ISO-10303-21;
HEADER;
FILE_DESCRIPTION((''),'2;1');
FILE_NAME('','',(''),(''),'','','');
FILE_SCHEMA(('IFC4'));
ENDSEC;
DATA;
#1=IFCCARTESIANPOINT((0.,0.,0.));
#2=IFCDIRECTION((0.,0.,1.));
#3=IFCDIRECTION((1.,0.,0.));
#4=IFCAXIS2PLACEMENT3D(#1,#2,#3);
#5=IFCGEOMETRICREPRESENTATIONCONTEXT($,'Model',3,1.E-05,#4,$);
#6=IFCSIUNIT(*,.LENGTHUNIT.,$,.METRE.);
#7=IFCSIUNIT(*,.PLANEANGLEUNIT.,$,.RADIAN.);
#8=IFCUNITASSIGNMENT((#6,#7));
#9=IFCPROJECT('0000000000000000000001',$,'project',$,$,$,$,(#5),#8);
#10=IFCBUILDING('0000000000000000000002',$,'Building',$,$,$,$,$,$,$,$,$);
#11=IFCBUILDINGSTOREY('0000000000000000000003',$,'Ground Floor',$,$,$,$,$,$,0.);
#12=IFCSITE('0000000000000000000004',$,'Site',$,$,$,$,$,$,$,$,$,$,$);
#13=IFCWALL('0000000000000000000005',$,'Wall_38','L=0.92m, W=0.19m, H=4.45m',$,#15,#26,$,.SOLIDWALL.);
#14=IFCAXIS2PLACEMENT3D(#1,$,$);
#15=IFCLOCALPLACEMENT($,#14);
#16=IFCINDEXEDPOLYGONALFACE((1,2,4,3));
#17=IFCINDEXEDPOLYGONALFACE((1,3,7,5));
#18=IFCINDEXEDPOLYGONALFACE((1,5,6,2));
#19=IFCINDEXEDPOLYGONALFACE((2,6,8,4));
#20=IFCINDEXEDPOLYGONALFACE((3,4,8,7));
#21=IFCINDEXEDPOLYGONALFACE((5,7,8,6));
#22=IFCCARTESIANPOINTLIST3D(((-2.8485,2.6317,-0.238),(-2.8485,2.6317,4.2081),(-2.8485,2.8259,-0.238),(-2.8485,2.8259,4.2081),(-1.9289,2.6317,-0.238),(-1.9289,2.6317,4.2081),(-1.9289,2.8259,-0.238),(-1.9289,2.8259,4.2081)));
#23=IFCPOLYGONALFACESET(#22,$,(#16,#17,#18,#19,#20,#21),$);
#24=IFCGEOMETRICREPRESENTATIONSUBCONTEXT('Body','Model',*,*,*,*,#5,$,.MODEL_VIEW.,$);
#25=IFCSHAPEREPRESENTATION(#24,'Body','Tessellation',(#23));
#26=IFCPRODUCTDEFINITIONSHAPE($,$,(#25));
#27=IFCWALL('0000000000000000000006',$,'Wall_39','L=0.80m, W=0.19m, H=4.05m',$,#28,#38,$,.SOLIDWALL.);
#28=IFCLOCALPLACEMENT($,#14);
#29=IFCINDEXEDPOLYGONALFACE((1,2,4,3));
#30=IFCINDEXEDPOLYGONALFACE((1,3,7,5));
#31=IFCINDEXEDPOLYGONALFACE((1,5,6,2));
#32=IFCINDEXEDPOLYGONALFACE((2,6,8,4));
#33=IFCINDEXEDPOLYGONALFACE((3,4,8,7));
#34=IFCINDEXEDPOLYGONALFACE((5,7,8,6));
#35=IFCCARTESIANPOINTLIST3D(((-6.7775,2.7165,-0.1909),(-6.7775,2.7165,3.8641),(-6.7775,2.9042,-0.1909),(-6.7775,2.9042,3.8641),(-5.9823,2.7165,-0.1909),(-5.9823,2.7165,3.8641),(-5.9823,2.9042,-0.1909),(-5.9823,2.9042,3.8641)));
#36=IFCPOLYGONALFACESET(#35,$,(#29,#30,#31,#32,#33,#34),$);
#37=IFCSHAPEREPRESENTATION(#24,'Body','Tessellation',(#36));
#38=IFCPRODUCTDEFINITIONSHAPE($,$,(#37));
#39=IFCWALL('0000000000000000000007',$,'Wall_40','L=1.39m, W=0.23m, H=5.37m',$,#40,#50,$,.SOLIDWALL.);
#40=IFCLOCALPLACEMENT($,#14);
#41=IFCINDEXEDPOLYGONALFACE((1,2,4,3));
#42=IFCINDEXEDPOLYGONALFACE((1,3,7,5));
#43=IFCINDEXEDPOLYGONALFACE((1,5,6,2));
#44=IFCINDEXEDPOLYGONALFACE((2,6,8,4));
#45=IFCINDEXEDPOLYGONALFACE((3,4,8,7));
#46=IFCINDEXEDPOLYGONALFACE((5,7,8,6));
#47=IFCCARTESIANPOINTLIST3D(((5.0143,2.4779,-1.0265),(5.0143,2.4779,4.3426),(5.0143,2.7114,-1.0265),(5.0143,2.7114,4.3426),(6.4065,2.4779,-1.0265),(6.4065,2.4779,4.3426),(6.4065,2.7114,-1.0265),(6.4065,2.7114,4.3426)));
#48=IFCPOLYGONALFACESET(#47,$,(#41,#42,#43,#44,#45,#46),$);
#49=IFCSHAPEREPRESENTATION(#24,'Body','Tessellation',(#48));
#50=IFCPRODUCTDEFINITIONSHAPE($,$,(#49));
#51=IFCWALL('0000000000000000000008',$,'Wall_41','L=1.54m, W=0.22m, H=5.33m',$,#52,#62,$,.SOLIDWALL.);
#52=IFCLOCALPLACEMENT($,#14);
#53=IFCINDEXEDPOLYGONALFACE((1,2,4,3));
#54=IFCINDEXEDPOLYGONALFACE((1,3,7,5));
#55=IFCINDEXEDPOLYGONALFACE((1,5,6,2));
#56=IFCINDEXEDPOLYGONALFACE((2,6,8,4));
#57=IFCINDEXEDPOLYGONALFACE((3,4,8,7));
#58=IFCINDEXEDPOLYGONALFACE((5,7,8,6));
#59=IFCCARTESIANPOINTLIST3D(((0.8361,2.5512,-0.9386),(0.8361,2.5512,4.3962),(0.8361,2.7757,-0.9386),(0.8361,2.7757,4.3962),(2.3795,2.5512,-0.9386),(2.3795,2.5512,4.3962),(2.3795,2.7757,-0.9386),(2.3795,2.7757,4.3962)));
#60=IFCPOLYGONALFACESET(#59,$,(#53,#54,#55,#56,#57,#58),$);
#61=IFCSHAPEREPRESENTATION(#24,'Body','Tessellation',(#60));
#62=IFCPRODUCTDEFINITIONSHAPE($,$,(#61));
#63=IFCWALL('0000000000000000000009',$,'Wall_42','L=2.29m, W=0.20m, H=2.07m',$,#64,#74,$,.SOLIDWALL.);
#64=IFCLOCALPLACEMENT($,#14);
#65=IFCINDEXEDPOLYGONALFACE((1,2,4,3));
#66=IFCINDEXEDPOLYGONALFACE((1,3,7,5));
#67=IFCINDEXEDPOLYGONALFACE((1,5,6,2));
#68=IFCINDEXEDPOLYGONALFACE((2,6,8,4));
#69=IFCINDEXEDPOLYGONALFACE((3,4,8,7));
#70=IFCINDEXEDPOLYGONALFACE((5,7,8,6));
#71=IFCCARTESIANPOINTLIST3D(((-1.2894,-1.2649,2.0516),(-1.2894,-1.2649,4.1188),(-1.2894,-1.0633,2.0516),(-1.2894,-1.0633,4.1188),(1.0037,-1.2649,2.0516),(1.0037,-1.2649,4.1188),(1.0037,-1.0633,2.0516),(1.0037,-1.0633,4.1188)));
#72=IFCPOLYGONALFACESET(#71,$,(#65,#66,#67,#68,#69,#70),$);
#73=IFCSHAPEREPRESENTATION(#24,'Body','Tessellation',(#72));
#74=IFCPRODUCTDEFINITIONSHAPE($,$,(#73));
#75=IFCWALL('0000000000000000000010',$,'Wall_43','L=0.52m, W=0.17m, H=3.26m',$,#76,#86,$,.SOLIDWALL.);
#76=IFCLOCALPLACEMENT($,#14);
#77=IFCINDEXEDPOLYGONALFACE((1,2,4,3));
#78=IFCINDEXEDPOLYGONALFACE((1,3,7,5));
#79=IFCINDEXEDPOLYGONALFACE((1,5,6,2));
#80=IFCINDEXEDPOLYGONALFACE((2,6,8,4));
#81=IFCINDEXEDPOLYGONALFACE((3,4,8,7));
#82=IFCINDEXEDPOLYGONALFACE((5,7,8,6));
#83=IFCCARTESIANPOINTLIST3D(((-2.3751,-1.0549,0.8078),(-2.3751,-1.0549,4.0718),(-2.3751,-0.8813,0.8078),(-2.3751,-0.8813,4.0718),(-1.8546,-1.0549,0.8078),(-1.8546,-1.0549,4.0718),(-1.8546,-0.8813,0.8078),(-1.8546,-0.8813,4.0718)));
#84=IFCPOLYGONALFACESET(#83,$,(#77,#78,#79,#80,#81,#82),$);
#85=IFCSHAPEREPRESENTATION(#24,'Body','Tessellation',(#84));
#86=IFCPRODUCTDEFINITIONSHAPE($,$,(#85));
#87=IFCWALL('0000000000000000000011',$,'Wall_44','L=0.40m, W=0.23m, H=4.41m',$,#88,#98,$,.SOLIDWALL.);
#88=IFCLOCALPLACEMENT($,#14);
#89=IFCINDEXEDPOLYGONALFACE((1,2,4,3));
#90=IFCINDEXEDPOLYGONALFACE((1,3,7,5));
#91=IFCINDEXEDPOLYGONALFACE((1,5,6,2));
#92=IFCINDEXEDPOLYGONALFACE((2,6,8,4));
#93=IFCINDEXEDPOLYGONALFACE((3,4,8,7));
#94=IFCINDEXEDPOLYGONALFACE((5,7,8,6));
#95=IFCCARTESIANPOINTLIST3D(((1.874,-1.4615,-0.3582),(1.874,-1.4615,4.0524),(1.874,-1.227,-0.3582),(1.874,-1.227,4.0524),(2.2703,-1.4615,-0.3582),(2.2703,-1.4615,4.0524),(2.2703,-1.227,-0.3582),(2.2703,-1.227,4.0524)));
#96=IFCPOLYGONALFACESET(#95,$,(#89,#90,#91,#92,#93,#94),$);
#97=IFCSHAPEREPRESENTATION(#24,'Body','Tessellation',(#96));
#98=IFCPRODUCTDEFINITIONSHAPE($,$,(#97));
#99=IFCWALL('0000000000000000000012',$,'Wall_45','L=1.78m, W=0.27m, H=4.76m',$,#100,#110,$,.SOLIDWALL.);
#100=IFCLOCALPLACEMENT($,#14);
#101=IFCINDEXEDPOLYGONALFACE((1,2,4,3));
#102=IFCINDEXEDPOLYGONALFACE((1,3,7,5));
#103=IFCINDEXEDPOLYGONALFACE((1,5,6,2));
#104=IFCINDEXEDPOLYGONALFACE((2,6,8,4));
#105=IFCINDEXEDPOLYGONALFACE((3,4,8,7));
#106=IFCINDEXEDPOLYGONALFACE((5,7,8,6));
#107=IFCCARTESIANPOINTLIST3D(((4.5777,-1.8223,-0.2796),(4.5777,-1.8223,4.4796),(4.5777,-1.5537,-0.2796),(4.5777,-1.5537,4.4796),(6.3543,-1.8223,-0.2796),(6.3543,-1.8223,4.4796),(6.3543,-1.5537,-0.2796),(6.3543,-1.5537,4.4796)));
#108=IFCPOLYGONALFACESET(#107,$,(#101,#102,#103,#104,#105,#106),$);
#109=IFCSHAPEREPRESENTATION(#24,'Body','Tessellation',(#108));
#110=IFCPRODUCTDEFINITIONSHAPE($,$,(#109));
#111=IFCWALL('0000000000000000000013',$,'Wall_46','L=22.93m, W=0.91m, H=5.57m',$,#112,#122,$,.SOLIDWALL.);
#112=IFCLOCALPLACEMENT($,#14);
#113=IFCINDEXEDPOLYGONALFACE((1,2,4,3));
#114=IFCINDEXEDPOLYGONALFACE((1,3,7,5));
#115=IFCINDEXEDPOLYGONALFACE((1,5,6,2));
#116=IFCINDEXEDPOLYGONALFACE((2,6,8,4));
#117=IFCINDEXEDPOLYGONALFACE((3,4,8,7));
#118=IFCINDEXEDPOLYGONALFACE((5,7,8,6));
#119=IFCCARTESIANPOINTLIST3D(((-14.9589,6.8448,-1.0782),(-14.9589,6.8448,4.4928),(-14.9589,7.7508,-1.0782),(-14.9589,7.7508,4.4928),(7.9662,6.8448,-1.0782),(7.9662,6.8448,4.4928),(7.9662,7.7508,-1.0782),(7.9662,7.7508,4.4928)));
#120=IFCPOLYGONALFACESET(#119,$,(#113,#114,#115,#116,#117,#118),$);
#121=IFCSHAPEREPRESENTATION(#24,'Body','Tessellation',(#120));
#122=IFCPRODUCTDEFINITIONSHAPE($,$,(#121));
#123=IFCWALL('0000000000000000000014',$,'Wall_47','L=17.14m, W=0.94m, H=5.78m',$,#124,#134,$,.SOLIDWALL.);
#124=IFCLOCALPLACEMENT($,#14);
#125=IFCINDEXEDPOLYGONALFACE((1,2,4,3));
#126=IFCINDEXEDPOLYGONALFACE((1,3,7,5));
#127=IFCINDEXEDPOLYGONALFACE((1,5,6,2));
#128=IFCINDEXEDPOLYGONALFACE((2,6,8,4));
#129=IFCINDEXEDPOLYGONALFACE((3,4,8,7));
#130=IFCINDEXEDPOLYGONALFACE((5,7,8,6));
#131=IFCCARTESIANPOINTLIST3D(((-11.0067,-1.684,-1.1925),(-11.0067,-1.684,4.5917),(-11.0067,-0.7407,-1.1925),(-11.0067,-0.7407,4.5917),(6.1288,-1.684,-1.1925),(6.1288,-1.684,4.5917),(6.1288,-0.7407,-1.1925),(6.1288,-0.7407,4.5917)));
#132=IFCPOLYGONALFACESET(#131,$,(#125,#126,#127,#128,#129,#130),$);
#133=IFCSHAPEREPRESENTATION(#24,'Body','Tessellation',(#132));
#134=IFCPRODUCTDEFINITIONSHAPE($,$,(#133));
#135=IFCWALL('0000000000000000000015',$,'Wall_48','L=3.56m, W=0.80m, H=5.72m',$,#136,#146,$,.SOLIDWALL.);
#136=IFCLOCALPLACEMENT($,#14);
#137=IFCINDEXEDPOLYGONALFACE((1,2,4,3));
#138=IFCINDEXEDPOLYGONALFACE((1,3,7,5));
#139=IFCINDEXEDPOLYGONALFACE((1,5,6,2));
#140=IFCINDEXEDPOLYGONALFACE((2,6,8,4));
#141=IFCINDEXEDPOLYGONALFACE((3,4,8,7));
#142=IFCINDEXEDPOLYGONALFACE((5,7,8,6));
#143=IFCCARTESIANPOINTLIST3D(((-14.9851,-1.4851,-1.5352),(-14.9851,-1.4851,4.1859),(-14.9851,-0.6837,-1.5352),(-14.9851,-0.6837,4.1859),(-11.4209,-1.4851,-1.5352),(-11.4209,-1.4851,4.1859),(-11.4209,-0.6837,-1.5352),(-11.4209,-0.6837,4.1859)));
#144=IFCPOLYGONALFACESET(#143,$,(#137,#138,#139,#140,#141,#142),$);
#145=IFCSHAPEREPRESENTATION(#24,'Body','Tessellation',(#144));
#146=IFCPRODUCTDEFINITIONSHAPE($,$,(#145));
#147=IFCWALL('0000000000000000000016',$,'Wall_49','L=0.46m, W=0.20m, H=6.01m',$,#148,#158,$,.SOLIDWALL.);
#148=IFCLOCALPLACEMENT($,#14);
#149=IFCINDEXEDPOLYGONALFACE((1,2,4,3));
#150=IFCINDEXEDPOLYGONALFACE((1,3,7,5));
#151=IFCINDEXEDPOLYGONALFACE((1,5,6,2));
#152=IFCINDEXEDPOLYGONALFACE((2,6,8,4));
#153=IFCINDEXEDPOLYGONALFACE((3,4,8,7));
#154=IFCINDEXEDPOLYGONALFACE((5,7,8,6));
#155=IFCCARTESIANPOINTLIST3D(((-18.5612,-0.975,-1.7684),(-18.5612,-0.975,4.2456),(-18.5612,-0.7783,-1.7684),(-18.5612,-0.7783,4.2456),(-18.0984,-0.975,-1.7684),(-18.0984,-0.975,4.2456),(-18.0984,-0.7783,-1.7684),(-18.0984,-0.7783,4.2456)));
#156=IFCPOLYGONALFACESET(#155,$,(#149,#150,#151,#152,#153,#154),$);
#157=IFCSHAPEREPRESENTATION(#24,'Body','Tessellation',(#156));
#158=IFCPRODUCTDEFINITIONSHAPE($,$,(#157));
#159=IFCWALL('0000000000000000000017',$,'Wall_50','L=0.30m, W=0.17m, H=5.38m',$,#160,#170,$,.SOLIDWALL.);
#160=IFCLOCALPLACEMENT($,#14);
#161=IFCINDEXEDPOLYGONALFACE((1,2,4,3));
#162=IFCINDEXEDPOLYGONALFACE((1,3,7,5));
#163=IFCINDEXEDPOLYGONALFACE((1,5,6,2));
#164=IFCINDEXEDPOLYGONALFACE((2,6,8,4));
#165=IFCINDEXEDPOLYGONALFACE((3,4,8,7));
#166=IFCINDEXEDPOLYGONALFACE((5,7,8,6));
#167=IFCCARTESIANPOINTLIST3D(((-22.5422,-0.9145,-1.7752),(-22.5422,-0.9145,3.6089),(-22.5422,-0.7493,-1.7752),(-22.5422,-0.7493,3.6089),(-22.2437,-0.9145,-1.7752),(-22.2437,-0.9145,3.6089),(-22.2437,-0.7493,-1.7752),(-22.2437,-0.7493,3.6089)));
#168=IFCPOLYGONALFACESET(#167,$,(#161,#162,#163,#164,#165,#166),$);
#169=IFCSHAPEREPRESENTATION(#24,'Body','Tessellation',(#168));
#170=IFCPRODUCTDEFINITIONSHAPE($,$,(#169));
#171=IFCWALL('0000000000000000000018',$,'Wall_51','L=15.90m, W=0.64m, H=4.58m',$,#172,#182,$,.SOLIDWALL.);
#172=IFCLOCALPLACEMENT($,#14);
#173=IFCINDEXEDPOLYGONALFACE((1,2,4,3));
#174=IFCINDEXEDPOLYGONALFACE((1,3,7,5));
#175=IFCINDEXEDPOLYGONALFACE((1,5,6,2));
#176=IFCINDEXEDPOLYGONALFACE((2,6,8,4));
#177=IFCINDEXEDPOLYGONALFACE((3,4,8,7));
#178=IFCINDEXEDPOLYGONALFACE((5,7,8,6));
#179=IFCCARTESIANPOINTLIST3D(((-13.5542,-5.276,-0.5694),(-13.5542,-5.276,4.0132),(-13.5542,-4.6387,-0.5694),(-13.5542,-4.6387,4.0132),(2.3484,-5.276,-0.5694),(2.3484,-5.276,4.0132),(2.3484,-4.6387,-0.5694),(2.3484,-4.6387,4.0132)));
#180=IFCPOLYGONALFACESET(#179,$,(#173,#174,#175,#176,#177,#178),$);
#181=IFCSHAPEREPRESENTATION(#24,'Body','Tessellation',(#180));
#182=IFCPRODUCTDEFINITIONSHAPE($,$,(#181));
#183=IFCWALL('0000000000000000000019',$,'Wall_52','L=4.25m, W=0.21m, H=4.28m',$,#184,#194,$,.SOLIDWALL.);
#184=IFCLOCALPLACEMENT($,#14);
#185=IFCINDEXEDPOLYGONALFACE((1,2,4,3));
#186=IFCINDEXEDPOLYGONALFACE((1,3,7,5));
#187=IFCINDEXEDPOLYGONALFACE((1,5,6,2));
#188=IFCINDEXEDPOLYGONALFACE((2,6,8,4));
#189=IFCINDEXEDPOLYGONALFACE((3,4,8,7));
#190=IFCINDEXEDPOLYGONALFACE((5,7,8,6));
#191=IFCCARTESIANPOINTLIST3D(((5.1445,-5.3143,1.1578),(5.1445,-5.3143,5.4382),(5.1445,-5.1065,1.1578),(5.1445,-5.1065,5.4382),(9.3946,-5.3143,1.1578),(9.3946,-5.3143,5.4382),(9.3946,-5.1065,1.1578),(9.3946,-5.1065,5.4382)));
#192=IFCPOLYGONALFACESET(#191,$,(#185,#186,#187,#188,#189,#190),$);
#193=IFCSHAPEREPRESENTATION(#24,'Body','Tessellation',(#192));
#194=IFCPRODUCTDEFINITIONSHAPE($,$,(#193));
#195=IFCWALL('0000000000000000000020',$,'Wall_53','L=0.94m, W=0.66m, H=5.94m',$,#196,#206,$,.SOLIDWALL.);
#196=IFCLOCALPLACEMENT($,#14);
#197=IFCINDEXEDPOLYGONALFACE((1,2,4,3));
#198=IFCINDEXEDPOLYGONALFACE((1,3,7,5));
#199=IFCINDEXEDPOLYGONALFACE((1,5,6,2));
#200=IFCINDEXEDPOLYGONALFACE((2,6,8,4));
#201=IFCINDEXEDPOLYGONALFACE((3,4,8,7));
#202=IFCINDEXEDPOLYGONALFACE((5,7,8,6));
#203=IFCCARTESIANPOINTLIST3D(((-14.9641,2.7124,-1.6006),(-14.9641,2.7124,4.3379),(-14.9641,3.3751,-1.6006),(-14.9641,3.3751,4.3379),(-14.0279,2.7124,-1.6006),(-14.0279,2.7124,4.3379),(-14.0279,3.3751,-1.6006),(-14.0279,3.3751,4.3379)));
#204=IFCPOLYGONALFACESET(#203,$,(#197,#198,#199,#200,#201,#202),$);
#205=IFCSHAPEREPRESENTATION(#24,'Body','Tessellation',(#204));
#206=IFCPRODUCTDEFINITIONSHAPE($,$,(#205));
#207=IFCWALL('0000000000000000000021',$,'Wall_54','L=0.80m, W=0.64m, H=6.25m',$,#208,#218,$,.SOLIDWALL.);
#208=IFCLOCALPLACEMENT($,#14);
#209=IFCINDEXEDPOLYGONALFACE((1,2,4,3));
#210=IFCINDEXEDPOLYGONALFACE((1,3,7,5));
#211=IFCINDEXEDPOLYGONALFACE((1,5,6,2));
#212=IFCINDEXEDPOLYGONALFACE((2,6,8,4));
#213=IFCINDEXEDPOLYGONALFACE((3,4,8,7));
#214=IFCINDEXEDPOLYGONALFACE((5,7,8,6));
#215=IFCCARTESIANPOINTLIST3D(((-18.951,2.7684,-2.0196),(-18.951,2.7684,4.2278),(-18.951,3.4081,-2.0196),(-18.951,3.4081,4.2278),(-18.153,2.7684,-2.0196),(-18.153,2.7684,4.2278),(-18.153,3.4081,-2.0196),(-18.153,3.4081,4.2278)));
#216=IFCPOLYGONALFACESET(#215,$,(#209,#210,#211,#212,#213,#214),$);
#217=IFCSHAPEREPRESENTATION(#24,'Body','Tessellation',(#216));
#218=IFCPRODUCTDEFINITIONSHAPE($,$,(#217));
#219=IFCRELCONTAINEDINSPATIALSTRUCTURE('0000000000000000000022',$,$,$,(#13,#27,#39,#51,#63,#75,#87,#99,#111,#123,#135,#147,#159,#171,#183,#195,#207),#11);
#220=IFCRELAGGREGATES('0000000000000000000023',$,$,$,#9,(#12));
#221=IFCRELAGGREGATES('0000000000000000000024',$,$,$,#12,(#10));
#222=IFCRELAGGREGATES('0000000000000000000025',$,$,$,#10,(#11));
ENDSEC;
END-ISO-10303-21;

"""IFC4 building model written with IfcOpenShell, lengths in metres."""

from ifc_helpers import new_model, si_unit, frame, origin_with_axes, origin_2d, context, subcontext, project, spatial, rectangle, extrude, element, save


model = new_model("IFC4")

# Units and contexts
model_context = context("Model", 3, precision=1e-05, world=origin_with_axes())
body_context = subcontext(model_context, "Body", "Model", "MODEL_VIEW")
ifc_project = project(units=[si_unit("LENGTHUNIT", "METRE"), si_unit("PLANEANGLEUNIT", "RADIAN")], contexts=[model_context])

# Site, building, storey
site = spatial("IfcSite", under=ifc_project, Name="Site")
building = spatial("IfcBuilding", under=site, Name="Building")
storey = spatial("IfcBuildingStorey", under=building, Name="Ground Floor", Elevation=0.0)

# Walls
element("IfcWall", 1, inside=storey, Name="Wall_38", Description="L=0.92m, W=0.19m, H=4.45m", PredefinedType="SOLIDWALL", context=body_context, shape_type="SweptSolid", body=[
    extrude(rectangle(XDim=0.9196, YDim=0.1942, at=origin_2d()), frame((-2.3887, 2.7288, -0.238), z_axis=(0.0, 0.0, 1.0), x_axis=(1.0, 0.0, 0.0)), (0.0, 0.0, 1.0), 4.4461),
])
element("IfcWall", 2, inside=storey, Name="Wall_39", Description="L=0.80m, W=0.19m, H=4.05m", PredefinedType="SOLIDWALL", context=body_context, shape_type="SweptSolid", body=[
    extrude(rectangle(XDim=0.7952, YDim=0.1877, at=origin_2d()), frame((-6.3799, 2.8103, -0.1909), z_axis=(0.0, 0.0, 1.0), x_axis=(1.0, 0.0, 0.0)), (0.0, 0.0, 1.0), 4.055),
])
element("IfcWall", 3, inside=storey, Name="Wall_40", Description="L=1.39m, W=0.23m, H=5.37m", PredefinedType="SOLIDWALL", context=body_context, shape_type="SweptSolid", body=[
    extrude(rectangle(XDim=1.3922, YDim=0.2334, at=origin_2d()), frame((5.7104, 2.5946, -1.0265), z_axis=(0.0, 0.0, 1.0), x_axis=(1.0, 0.0, 0.0)), (0.0, 0.0, 1.0), 5.369),
])
element("IfcWall", 4, inside=storey, Name="Wall_41", Description="L=1.54m, W=0.22m, H=5.33m", PredefinedType="SOLIDWALL", context=body_context, shape_type="SweptSolid", body=[
    extrude(rectangle(XDim=1.5434, YDim=0.2246, at=origin_2d()), frame((1.6078, 2.6634, -0.9386), z_axis=(0.0, 0.0, 1.0), x_axis=(1.0, 0.0, 0.0)), (0.0, 0.0, 1.0), 5.3348),
])
element("IfcWall", 5, inside=storey, Name="Wall_42", Description="L=2.29m, W=0.20m, H=2.07m", PredefinedType="SOLIDWALL", context=body_context, shape_type="SweptSolid", body=[
    extrude(rectangle(XDim=2.293, YDim=0.2016, at=origin_2d()), frame((-0.1429, -1.1641, 2.0516), z_axis=(0.0, 0.0, 1.0), x_axis=(1.0, 0.0, 0.0)), (0.0, 0.0, 1.0), 2.0672),
])
element("IfcWall", 6, inside=storey, Name="Wall_43", Description="L=0.52m, W=0.17m, H=3.26m", PredefinedType="SOLIDWALL", context=body_context, shape_type="SweptSolid", body=[
    extrude(rectangle(XDim=0.5205, YDim=0.1736, at=origin_2d()), frame((-2.1148, -0.9681, 0.8078), z_axis=(0.0, 0.0, 1.0), x_axis=(1.0, 0.0, 0.0)), (0.0, 0.0, 1.0), 3.264),
])
element("IfcWall", 7, inside=storey, Name="Wall_44", Description="L=0.40m, W=0.23m, H=4.41m", PredefinedType="SOLIDWALL", context=body_context, shape_type="SweptSolid", body=[
    extrude(rectangle(XDim=0.3962, YDim=0.2344, at=origin_2d()), frame((2.0721, -1.3442, -0.3582), z_axis=(0.0, 0.0, 1.0), x_axis=(1.0, 0.0, 0.0)), (0.0, 0.0, 1.0), 4.4106),
])
element("IfcWall", 8, inside=storey, Name="Wall_45", Description="L=1.78m, W=0.27m, H=4.76m", PredefinedType="SOLIDWALL", context=body_context, shape_type="SweptSolid", body=[
    extrude(rectangle(XDim=1.7765, YDim=0.2686, at=origin_2d()), frame((5.466, -1.688, -0.2796), z_axis=(0.0, 0.0, 1.0), x_axis=(1.0, 0.0, 0.0)), (0.0, 0.0, 1.0), 4.7592),
])
element("IfcWall", 9, inside=storey, Name="Wall_46", Description="L=22.93m, W=0.91m, H=5.57m", PredefinedType="SOLIDWALL", context=body_context, shape_type="SweptSolid", body=[
    extrude(rectangle(XDim=22.9251, YDim=0.906, at=origin_2d()), frame((-3.4964, 7.2978, -1.0782), z_axis=(0.0, 0.0, 1.0), x_axis=(1.0, 0.0, 0.0)), (0.0, 0.0, 1.0), 5.571),
])
element("IfcWall", 10, inside=storey, Name="Wall_47", Description="L=17.14m, W=0.94m, H=5.78m", PredefinedType="SOLIDWALL", context=body_context, shape_type="SweptSolid", body=[
    extrude(rectangle(XDim=17.1355, YDim=0.9433, at=origin_2d()), frame((-2.4389, -1.2124, -1.1925), z_axis=(0.0, 0.0, 1.0), x_axis=(1.0, 0.0, 0.0)), (0.0, 0.0, 1.0), 5.7842),
])
element("IfcWall", 11, inside=storey, Name="Wall_48", Description="L=3.56m, W=0.80m, H=5.72m", PredefinedType="SOLIDWALL", context=body_context, shape_type="SweptSolid", body=[
    extrude(rectangle(XDim=3.5642, YDim=0.8014, at=origin_2d()), frame((-13.203, -1.0844, -1.5352), z_axis=(0.0, 0.0, 1.0), x_axis=(1.0, 0.0, 0.0)), (0.0, 0.0, 1.0), 5.7211),
])
element("IfcWall", 12, inside=storey, Name="Wall_49", Description="L=0.46m, W=0.20m, H=6.01m", PredefinedType="SOLIDWALL", context=body_context, shape_type="SweptSolid", body=[
    extrude(rectangle(XDim=0.4628, YDim=0.1967, at=origin_2d()), frame((-18.3298, -0.8766, -1.7684), z_axis=(0.0, 0.0, 1.0), x_axis=(1.0, 0.0, 0.0)), (0.0, 0.0, 1.0), 6.014),
])
element("IfcWall", 13, inside=storey, Name="Wall_50", Description="L=0.30m, W=0.17m, H=5.38m", PredefinedType="SOLIDWALL", context=body_context, shape_type="SweptSolid", body=[
    extrude(rectangle(XDim=0.2985, YDim=0.1652, at=origin_2d()), frame((-22.3929, -0.8319, -1.7752), z_axis=(0.0, 0.0, 1.0), x_axis=(1.0, 0.0, 0.0)), (0.0, 0.0, 1.0), 5.3841),
])
element("IfcWall", 14, inside=storey, Name="Wall_51", Description="L=15.90m, W=0.64m, H=4.58m", PredefinedType="SOLIDWALL", context=body_context, shape_type="SweptSolid", body=[
    extrude(rectangle(XDim=15.9026, YDim=0.6373, at=origin_2d()), frame((-5.6029, -4.9573, -0.5694), z_axis=(0.0, 0.0, 1.0), x_axis=(1.0, 0.0, 0.0)), (0.0, 0.0, 1.0), 4.5827),
])
element("IfcWall", 15, inside=storey, Name="Wall_52", Description="L=4.25m, W=0.21m, H=4.28m", PredefinedType="SOLIDWALL", context=body_context, shape_type="SweptSolid", body=[
    extrude(rectangle(XDim=4.2501, YDim=0.2079, at=origin_2d()), frame((7.2695, -5.2104, 1.1578), z_axis=(0.0, 0.0, 1.0), x_axis=(1.0, 0.0, 0.0)), (0.0, 0.0, 1.0), 4.2804),
])
element("IfcWall", 16, inside=storey, Name="Wall_53", Description="L=0.94m, W=0.66m, H=5.94m", PredefinedType="SOLIDWALL", context=body_context, shape_type="SweptSolid", body=[
    extrude(rectangle(XDim=0.9362, YDim=0.6626, at=origin_2d()), frame((-14.496, 3.0438, -1.6006), z_axis=(0.0, 0.0, 1.0), x_axis=(1.0, 0.0, 0.0)), (0.0, 0.0, 1.0), 5.9385),
])
element("IfcWall", 17, inside=storey, Name="Wall_54", Description="L=0.80m, W=0.64m, H=6.25m", PredefinedType="SOLIDWALL", context=body_context, shape_type="SweptSolid", body=[
    extrude(rectangle(XDim=0.7979, YDim=0.6396, at=origin_2d()), frame((-18.552, 3.0883, -2.0196), z_axis=(0.0, 0.0, 1.0), x_axis=(1.0, 0.0, 0.0)), (0.0, 0.0, 1.0), 6.2474),
])

save(model, "model.ifc")
